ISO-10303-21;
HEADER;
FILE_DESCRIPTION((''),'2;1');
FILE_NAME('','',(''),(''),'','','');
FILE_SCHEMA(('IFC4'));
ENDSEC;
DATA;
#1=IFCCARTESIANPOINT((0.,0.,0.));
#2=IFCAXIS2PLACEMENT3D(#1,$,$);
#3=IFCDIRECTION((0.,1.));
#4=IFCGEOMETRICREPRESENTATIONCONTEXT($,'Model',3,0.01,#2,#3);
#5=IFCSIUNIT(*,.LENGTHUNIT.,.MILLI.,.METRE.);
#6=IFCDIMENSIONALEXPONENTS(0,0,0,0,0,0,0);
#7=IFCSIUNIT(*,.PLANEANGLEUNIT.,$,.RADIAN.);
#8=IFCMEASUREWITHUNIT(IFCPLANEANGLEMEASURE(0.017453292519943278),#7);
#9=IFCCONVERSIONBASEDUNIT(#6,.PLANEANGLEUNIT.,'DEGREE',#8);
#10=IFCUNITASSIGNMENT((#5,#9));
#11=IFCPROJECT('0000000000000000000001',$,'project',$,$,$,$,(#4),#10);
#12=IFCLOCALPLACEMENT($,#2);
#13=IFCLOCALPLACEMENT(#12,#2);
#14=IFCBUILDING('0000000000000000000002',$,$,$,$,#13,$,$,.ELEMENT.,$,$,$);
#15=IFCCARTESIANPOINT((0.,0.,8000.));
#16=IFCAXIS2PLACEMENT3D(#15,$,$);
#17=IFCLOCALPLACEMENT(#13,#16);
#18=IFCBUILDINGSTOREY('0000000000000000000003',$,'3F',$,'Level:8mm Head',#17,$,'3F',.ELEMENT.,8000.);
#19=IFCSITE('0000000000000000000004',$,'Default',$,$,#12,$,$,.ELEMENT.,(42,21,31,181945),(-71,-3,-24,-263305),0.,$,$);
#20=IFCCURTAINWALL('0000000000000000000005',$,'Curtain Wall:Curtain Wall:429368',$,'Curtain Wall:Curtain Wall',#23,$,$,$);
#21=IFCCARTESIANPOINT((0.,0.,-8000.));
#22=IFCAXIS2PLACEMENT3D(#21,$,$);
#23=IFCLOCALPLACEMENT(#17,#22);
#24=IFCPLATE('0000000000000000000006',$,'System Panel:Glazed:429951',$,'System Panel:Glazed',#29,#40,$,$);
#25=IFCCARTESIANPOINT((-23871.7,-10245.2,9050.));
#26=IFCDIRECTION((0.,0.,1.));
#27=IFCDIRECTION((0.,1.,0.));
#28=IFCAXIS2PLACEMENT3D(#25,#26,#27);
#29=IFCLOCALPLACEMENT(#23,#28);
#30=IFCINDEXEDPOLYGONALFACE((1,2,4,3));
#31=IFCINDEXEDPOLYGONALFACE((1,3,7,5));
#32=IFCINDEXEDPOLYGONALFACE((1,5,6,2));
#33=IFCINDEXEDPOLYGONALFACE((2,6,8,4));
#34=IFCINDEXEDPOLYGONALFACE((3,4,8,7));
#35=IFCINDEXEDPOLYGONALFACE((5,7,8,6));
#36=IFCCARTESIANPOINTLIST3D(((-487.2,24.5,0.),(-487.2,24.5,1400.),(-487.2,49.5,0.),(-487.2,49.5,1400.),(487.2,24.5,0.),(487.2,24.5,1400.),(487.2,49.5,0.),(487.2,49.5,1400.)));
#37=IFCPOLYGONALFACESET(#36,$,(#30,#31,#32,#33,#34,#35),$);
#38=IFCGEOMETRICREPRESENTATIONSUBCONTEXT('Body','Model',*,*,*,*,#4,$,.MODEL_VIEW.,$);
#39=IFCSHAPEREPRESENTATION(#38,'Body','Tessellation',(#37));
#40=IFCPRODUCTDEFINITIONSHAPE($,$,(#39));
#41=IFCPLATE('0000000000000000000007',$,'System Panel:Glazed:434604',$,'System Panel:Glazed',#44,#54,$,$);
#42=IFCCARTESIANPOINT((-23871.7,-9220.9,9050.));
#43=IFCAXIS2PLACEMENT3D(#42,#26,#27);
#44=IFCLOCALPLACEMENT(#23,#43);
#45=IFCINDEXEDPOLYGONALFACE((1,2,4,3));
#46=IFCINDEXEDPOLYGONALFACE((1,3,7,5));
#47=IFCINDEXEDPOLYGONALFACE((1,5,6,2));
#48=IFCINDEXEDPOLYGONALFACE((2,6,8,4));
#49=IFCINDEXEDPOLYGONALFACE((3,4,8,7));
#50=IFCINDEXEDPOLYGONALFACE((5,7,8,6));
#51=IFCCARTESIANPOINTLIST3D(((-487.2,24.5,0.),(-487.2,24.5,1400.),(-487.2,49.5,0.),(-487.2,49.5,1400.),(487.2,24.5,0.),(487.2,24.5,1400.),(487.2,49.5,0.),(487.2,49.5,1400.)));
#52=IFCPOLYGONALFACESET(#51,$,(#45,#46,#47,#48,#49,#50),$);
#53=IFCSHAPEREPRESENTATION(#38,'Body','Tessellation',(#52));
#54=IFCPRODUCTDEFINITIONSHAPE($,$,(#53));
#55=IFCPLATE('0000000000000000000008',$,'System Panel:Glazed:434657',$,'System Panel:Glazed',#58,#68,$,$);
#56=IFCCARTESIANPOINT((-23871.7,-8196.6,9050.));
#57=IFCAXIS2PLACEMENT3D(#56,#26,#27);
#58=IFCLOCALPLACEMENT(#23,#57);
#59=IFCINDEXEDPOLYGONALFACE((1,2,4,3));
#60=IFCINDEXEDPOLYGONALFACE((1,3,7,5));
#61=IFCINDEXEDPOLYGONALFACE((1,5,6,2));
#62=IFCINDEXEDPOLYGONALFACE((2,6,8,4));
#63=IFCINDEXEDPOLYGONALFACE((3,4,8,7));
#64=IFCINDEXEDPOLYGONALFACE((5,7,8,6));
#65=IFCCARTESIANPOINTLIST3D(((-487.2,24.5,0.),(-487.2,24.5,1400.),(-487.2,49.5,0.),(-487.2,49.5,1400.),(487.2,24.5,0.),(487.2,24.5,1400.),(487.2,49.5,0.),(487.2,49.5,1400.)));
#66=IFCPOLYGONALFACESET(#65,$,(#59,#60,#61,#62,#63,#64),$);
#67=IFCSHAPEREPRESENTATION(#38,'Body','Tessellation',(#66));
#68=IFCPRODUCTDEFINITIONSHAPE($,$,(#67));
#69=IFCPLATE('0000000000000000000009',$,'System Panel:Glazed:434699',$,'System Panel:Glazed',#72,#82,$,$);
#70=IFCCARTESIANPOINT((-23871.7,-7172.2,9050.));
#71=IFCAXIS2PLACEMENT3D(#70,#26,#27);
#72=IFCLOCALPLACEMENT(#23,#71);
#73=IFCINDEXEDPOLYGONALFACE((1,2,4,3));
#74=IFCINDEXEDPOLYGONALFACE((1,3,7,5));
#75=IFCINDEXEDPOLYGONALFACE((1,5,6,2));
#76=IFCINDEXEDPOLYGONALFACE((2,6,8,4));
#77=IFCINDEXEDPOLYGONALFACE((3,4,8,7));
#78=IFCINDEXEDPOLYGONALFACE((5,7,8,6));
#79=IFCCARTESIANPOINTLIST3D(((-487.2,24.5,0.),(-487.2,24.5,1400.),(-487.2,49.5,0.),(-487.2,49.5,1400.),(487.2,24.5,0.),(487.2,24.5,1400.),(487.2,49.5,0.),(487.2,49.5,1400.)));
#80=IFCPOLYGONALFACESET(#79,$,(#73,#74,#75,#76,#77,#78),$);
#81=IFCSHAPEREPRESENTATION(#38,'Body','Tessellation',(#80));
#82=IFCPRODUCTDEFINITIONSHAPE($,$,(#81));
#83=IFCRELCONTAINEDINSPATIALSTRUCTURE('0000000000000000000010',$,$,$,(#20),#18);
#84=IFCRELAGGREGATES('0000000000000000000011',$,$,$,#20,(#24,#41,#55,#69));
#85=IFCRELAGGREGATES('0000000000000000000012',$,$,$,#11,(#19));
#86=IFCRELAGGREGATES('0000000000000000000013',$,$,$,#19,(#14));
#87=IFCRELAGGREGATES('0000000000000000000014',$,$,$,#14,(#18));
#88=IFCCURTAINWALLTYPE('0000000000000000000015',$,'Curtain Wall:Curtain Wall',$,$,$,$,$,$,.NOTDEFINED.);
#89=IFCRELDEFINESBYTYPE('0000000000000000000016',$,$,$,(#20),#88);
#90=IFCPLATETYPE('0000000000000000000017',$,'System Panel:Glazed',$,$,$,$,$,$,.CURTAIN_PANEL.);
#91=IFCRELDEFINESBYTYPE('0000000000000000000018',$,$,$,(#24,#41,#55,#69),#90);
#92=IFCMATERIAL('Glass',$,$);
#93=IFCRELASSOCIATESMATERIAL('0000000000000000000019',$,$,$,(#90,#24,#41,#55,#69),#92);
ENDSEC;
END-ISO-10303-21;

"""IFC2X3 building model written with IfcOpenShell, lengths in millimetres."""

from ifc_helpers import new_model, entity, si_unit, converted_unit, direction, frame, origin, origin_2d_with_axis, place, context, subcontext, project, spatial, rectangle, extrude, source, transform, mapped, material, type_object, type_shapes, element, aggregate, save


model = new_model("IFC2X3")

# Units and contexts
model_context = context("Model", 3, precision=0.01, world=origin(), true_north=direction((0.0, 1.0)))
body_context = subcontext(model_context, "Body", "Model", "MODEL_VIEW")
ifc_project = project(units=[si_unit("LENGTHUNIT", "METRE", prefix="MILLI"), converted_unit("PLANEANGLEUNIT", "DEGREE", entity("IfcPlaneAngleMeasure", 0.017453292519943278), si_unit("PLANEANGLEUNIT", "RADIAN"), dimensions=[0, 0, 0, 0, 0, 0, 0])], contexts=[model_context])

# Site, building, storey
site_placement = place(None, origin())
site = spatial("IfcSite", under=ifc_project, at=site_placement, Name="Default", CompositionType="ELEMENT", RefLatitude=(42, 21, 31, 181945), RefLongitude=(-71, -3, -24, -263305), RefElevation=0.0)
building_placement = place(site_placement, origin())
building = spatial("IfcBuilding", under=site, at=building_placement, CompositionType="ELEMENT")
storey_placement = place(building_placement, frame((0.0, 0.0, 8000.0)))
storey = spatial("IfcBuildingStorey", under=building, at=storey_placement, Name="3F", ObjectType="Level:8mm Head", LongName="3F", CompositionType="ELEMENT", Elevation=8000.0)

# Curtain wall
curtain_wall_type = type_object("IfcCurtainWallType", Name="Curtain Wall:Curtain Wall", PredefinedType="NOTDEFINED")
curtain_wall_placement = place(storey_placement, frame((0.0, 0.0, -8000.0)))
curtain_wall = element("IfcCurtainWall", 1, at=curtain_wall_placement, inside=storey, type_object=curtain_wall_type, Name="Curtain Wall:Curtain Wall:429368", ObjectType="Curtain Wall:Curtain Wall")

# Plates
ifc_material_1 = material(Name="Glass")
plate_type = type_object("IfcPlateType", Name="System Panel:Glazed", PredefinedType="CURTAIN_PANEL", material=ifc_material_1)
shared_shape_1 = source(origin(), body_context, "Body", "SweptSolid", [
    extrude(rectangle(XDim=25.0, YDim=974.3, at=origin_2d_with_axis()), frame((0.0, 37.0, 0.0), z_axis=(0.0, 0.0, 1.0), x_axis=(0.0, 1.0, 0.0)), (0.0, 0.0, 1.0), 1400.0),
])
type_shapes(plate_type, [shared_shape_1])
plate_1_placement = place(curtain_wall_placement, frame((-23871.7, -10245.2, 9050.0), z_axis=(0.0, 0.0, 1.0), x_axis=(0.0, 1.0, 0.0)))
plate_1 = element("IfcPlate", 2, at=plate_1_placement, type_object=plate_type, material=ifc_material_1, Name="System Panel:Glazed:429951", ObjectType="System Panel:Glazed", context=body_context, shape_type="MappedRepresentation", body=[
    mapped(shared_shape_1, transform((0.0, 0.0, 0.0), scale=1.0)),
])
plate_2_placement = place(curtain_wall_placement, frame((-23871.7, -9220.9, 9050.0), z_axis=(0.0, 0.0, 1.0), x_axis=(0.0, 1.0, 0.0)))
plate_2 = element("IfcPlate", 3, at=plate_2_placement, type_object=plate_type, material=ifc_material_1, Name="System Panel:Glazed:434604", ObjectType="System Panel:Glazed", context=body_context, shape_type="MappedRepresentation", body=[
    mapped(shared_shape_1, transform((0.0, 0.0, 0.0), scale=1.0)),
])
plate_3_placement = place(curtain_wall_placement, frame((-23871.7, -8196.6, 9050.0), z_axis=(0.0, 0.0, 1.0), x_axis=(0.0, 1.0, 0.0)))
plate_3 = element("IfcPlate", 4, at=plate_3_placement, type_object=plate_type, material=ifc_material_1, Name="System Panel:Glazed:434657", ObjectType="System Panel:Glazed", context=body_context, shape_type="MappedRepresentation", body=[
    mapped(shared_shape_1, transform((0.0, 0.0, 0.0), scale=1.0)),
])
plate_4_placement = place(curtain_wall_placement, frame((-23871.7, -7172.2, 9050.0), z_axis=(0.0, 0.0, 1.0), x_axis=(0.0, 1.0, 0.0)))
plate_4 = element("IfcPlate", 5, at=plate_4_placement, type_object=plate_type, material=ifc_material_1, Name="System Panel:Glazed:434699", ObjectType="System Panel:Glazed", context=body_context, shape_type="MappedRepresentation", body=[
    mapped(shared_shape_1, transform((0.0, 0.0, 0.0), scale=1.0)),
])
aggregate(curtain_wall, [plate_1, plate_2, plate_3, plate_4])

save(model, "model.ifc")
